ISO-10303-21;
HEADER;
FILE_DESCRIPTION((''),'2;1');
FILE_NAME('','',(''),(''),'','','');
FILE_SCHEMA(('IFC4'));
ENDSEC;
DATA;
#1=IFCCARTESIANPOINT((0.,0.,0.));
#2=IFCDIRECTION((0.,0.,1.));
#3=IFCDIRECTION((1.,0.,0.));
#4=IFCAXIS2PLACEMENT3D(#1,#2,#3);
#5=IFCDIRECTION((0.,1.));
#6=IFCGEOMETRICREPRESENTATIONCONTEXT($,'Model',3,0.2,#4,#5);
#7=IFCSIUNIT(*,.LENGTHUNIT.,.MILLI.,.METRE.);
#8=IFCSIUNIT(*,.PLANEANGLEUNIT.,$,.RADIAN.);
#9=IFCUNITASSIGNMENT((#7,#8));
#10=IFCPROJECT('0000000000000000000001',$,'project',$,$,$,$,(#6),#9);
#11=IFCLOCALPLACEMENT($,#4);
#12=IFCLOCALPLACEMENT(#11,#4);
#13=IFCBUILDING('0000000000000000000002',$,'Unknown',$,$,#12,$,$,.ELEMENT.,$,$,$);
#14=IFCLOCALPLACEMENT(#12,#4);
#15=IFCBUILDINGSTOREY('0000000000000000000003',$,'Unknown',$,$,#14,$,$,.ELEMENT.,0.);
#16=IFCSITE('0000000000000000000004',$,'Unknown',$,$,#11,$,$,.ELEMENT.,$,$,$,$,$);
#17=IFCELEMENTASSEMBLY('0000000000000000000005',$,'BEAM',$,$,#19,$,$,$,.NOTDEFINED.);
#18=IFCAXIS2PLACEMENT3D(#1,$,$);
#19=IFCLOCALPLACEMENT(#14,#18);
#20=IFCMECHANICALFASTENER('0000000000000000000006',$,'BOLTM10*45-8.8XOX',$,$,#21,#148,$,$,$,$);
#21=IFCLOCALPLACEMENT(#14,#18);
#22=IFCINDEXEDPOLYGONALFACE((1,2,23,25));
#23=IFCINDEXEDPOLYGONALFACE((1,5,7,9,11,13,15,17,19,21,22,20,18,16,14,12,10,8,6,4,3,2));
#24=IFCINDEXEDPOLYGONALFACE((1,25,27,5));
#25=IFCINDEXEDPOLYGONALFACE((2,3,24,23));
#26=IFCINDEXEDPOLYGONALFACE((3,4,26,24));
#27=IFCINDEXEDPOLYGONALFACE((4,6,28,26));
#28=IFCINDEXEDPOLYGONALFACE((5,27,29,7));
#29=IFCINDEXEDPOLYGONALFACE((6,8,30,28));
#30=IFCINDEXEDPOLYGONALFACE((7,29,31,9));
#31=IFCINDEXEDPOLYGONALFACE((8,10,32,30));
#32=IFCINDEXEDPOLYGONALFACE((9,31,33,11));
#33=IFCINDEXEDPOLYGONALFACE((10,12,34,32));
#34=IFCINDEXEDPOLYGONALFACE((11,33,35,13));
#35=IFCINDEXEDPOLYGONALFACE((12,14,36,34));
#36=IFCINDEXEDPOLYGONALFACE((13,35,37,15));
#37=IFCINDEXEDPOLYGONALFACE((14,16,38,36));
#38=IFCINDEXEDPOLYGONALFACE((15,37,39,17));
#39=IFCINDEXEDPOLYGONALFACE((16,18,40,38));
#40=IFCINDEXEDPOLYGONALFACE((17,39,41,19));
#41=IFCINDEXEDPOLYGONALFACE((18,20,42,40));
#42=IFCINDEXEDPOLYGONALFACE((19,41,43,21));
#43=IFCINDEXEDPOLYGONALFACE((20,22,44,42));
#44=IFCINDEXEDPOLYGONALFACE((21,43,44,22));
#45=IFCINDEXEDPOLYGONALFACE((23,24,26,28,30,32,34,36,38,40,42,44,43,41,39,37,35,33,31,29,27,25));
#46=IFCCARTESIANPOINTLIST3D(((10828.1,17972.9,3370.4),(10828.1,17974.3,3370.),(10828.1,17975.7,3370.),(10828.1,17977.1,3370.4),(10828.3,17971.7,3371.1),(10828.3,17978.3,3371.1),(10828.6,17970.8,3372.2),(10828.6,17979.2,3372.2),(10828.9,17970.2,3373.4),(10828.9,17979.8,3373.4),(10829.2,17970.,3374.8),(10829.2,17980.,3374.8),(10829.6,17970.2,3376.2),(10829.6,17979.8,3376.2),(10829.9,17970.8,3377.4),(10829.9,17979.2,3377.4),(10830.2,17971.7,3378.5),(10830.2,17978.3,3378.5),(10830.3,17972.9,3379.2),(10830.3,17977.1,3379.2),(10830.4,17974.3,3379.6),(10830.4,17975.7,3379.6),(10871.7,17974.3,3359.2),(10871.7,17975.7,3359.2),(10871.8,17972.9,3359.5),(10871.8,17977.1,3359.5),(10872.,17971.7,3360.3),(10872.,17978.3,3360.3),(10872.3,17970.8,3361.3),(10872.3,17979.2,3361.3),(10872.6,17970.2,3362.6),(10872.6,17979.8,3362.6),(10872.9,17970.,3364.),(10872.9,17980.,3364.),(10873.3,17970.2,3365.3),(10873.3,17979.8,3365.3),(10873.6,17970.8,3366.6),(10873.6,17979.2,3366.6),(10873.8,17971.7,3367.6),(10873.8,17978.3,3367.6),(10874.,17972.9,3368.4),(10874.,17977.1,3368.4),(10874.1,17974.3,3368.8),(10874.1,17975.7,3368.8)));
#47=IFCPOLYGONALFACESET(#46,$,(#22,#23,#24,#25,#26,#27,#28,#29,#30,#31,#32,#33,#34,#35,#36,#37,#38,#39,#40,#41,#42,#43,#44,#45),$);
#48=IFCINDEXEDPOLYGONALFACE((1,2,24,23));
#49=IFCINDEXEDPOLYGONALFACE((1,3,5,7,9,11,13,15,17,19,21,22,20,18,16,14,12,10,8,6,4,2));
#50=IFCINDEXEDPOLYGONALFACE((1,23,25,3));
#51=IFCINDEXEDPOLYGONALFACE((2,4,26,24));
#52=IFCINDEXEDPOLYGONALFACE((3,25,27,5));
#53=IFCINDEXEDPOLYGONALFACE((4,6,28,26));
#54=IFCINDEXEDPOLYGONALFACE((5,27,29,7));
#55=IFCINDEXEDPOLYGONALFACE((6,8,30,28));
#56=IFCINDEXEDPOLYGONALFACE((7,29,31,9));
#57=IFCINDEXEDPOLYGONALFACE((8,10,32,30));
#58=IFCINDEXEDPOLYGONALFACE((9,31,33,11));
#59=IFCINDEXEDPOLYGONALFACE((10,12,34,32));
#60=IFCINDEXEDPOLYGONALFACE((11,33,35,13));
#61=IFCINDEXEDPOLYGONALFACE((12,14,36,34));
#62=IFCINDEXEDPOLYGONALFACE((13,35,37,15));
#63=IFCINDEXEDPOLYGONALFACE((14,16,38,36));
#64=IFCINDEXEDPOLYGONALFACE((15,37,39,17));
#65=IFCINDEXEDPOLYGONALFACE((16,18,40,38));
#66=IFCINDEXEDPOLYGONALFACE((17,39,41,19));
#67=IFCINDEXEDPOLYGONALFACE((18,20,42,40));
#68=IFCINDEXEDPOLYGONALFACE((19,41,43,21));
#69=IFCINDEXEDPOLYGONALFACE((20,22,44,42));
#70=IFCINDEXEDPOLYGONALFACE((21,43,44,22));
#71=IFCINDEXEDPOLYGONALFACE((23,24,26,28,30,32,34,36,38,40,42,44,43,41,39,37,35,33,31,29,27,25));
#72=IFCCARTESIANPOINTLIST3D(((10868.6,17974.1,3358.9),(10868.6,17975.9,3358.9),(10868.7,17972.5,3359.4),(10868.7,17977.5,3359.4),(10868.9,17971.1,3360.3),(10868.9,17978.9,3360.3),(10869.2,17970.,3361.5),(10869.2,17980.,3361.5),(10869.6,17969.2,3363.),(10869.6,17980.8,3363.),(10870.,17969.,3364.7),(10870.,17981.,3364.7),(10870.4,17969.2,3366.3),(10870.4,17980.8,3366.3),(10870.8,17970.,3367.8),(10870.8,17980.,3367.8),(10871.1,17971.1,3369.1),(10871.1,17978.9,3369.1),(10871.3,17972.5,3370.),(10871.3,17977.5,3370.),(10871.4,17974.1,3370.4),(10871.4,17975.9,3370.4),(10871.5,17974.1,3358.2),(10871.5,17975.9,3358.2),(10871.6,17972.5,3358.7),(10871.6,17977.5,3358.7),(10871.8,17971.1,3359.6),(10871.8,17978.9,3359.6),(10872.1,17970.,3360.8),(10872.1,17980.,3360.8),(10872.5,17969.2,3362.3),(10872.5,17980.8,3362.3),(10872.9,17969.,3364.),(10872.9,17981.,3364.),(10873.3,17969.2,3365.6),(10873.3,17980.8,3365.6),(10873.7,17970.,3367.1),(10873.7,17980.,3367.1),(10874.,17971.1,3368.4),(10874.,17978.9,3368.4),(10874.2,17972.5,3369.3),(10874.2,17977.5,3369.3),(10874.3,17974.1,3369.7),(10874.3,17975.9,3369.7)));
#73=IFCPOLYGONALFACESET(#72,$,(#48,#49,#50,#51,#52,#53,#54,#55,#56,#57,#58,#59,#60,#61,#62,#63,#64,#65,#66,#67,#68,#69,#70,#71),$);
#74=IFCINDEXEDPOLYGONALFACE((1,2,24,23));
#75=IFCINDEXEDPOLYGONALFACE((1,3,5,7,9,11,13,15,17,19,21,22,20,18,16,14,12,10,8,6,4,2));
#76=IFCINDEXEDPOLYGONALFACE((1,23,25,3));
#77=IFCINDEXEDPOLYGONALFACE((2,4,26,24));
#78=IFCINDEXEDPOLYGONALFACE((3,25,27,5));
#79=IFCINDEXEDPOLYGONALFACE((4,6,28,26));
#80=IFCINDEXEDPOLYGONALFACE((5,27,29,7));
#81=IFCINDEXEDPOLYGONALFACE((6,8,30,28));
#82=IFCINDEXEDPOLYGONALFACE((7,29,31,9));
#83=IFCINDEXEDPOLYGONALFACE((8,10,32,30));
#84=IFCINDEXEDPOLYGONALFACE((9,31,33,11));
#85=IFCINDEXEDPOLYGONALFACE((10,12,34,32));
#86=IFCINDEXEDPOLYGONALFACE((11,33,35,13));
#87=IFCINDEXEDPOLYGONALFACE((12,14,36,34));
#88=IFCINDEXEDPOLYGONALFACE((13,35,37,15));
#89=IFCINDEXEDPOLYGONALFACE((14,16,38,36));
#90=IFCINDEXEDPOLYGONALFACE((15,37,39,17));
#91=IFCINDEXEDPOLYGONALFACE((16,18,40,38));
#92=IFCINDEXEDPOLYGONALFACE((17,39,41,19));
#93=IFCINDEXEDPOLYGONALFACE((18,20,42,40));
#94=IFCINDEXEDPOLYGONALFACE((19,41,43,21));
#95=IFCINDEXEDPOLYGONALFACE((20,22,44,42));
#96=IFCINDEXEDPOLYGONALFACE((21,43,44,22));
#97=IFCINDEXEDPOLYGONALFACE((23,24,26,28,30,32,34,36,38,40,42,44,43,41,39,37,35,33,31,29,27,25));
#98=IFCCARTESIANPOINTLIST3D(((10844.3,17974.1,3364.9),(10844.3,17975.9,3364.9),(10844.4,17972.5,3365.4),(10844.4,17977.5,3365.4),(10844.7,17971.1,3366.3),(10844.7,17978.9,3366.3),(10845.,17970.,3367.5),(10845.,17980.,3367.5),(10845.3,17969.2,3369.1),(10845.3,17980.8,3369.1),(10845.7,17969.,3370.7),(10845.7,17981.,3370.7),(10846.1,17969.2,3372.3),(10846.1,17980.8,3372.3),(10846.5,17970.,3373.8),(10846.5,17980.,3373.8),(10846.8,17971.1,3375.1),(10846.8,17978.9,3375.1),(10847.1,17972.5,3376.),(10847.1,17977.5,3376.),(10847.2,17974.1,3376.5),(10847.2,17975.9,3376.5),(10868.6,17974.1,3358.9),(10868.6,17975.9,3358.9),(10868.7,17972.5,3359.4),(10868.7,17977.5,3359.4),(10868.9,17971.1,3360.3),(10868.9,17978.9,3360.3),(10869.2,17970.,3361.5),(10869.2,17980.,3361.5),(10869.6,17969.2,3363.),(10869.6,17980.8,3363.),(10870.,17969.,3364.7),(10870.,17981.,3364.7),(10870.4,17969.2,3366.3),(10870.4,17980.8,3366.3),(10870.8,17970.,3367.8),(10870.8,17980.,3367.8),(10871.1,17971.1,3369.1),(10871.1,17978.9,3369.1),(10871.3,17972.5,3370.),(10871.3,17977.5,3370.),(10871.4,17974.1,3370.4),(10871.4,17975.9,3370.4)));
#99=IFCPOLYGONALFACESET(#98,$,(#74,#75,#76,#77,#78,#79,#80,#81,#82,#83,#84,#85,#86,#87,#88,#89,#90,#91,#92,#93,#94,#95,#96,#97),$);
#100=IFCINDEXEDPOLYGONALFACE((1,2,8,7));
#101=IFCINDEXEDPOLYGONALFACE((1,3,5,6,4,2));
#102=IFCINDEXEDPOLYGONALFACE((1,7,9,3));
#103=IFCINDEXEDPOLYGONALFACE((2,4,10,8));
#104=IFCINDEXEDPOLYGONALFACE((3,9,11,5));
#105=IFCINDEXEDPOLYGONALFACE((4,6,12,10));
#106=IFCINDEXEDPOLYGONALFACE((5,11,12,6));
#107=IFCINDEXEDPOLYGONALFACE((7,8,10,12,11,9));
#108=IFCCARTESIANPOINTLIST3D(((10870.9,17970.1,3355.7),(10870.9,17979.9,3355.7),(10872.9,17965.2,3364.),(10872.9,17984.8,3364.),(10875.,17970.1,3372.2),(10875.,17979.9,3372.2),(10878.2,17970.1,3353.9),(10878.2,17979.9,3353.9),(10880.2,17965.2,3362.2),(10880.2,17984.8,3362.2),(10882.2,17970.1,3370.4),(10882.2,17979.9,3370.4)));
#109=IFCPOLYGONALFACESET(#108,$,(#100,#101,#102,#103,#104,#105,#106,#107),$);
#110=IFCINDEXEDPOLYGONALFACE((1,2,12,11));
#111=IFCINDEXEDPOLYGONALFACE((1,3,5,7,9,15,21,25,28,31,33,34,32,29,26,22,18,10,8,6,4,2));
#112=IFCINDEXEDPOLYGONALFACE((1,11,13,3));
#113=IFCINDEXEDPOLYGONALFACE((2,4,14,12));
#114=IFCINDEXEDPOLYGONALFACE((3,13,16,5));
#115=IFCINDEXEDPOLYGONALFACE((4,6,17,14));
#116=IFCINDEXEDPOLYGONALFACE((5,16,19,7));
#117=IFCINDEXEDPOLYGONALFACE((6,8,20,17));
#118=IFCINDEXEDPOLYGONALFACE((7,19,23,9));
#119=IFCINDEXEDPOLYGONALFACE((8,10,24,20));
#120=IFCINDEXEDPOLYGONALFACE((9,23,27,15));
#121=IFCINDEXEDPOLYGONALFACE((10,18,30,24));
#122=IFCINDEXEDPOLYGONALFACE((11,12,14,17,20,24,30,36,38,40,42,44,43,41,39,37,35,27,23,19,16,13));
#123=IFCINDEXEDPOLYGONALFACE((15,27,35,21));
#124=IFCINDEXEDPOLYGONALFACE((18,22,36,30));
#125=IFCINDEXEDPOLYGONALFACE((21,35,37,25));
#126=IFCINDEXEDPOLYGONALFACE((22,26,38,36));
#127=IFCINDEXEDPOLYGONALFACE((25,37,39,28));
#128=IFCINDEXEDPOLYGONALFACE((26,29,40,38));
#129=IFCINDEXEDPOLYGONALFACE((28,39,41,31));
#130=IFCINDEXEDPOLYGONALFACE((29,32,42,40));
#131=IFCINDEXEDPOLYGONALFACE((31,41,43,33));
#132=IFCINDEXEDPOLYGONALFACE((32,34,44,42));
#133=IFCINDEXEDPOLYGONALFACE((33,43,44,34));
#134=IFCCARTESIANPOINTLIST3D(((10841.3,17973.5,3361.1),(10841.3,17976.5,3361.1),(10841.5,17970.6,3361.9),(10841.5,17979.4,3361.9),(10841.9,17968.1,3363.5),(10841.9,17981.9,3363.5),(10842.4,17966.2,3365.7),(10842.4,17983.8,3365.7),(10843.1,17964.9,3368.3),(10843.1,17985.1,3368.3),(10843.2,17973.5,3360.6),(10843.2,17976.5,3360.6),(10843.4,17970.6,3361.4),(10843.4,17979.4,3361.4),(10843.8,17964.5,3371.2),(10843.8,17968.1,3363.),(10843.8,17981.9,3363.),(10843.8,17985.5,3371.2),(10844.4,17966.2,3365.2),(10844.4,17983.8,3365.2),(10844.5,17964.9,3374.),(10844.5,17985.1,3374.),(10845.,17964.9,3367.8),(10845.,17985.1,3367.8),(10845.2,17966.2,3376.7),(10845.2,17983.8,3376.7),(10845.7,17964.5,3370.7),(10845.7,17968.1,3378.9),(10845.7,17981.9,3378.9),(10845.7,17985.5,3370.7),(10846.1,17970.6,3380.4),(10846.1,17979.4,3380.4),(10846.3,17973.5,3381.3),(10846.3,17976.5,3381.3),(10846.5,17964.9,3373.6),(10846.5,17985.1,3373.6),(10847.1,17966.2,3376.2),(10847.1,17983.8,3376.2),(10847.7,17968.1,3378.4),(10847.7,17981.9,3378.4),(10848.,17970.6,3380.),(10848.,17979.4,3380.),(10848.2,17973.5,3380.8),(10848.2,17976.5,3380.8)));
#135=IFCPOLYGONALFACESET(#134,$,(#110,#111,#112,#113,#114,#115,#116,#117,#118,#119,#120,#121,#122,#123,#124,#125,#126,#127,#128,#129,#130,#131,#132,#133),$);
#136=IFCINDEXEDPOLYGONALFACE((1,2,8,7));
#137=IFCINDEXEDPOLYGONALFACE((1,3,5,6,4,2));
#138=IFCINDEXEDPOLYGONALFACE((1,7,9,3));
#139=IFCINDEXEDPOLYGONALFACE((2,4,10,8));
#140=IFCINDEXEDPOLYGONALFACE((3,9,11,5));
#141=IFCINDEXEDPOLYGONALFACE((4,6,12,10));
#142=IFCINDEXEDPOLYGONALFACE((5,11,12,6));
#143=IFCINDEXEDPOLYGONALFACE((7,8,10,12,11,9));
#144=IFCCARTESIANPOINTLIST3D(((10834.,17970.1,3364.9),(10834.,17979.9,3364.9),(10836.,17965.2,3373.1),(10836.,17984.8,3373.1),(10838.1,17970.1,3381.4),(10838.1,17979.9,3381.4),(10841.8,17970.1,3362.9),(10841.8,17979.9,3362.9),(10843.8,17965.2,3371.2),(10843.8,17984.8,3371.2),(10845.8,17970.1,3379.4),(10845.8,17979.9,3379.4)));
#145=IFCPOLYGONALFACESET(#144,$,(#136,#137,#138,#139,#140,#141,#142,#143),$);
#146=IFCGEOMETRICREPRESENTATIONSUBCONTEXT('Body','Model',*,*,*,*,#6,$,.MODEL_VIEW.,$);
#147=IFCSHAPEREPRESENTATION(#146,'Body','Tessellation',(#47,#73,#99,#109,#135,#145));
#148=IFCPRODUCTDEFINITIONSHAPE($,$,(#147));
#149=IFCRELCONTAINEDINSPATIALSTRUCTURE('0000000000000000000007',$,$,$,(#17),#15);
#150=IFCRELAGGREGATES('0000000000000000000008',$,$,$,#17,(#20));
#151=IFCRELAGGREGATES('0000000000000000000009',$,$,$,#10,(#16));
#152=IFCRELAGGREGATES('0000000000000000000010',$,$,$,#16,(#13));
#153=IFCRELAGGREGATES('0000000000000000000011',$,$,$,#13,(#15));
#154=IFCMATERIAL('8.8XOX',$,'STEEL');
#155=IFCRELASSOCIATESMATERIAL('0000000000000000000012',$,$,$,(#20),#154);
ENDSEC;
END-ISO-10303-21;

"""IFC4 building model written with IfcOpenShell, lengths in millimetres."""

from ifc_helpers import new_model, si_unit, direction, frame, origin_with_axes, place, context, subcontext, project, spatial, line, arc, indexed_curve, outline, extrude, source, transform, mapped, material, element, aggregate, save


model = new_model("IFC4")

# Units and contexts
model_context = context("Model", 3, precision=0.2, world=origin_with_axes(), true_north=direction((0.0, 1.0)))
body_context = subcontext(model_context, "Body", "Model", "MODEL_VIEW")
ifc_project = project(units=[si_unit("LENGTHUNIT", "METRE", prefix="MILLI"), si_unit("PLANEANGLEUNIT", "RADIAN")], contexts=[model_context])

# Site, building, storey
site_placement = place(None, origin_with_axes())
site = spatial("IfcSite", under=ifc_project, at=site_placement, Name="Unknown", CompositionType="ELEMENT")
building_placement = place(site_placement, origin_with_axes())
building = spatial("IfcBuilding", under=site, at=building_placement, Name="Unknown", CompositionType="ELEMENT")
storey_placement = place(building_placement, origin_with_axes())
storey = spatial("IfcBuildingStorey", under=building, at=storey_placement, Name="Unknown", CompositionType="ELEMENT", Elevation=0.0)

# Shared definitions
ifc_material_1 = material(Name="8.8XOX", Category="STEEL")

# Element assembly, mechanical fastener
shared_shape_1 = source(origin_with_axes(), body_context, "Body", "SweptSolid", [
    extrude(outline(indexed_curve([(5.0, 0.0), (0.0, 5.0), (-5.0, 0.0), (0.0, -5.0)], segments=[arc(1, 2, 3), arc(3, 4, 1)])), frame((0.0, 0.0, 3.8), z_axis=(0.0, 0.0, -1.0), x_axis=(0.0, 1.0, 0.0)), (0.0, 0.0, 1.0), 45.0),
    extrude(outline(indexed_curve([(6.0, 0.0), (0.0, 6.0), (-6.0, 0.0), (0.0, -6.0)], segments=[arc(1, 2, 3), arc(3, 4, 1)])), frame((0.0, 0.0, 3.8), z_axis=(0.0, 0.0, -1.0), x_axis=(0.0, 1.0, 0.0)), (0.0, 0.0, 1.0), 3.0),
    extrude(outline(indexed_curve([(6.0, 0.0), (0.0, 6.0), (-6.0, 0.0), (0.0, -6.0)], segments=[arc(1, 2, 3), arc(3, 4, 1)])), frame((0.0, 0.0, 0.8), z_axis=(0.0, 0.0, -1.0), x_axis=(0.0, 1.0, 0.0)), (0.0, 0.0, 1.0), 25.0),
    extrude(outline(indexed_curve([(9.8, 0.0), (4.9, 8.5), (-4.9, 8.5), (-9.8, 0.0), (-4.9, -8.5), (4.9, -8.5)], segments=[line(1, 2, 3, 4, 5, 6, 1)])), frame((0.0, 0.0, 11.2), z_axis=(0.0, 0.0, -1.0), x_axis=(0.0, 1.0, 0.0)), (0.0, 0.0, 1.0), 7.5),
    extrude(outline(indexed_curve([(10.5, 0.0), (0.0, 10.5), (-10.5, 0.0), (0.0, -10.5)], segments=[arc(1, 2, 3), arc(3, 4, 1)])), frame((0.0, 0.0, -24.2), z_axis=(0.0, 0.0, -1.0), x_axis=(0.0, 1.0, 0.0)), (0.0, 0.0, 1.0), 2.0),
    extrude(outline(indexed_curve([(9.8, 0.0), (4.9, 8.5), (-4.9, 8.5), (-9.8, 0.0), (-4.9, -8.5), (4.9, -8.5)], segments=[line(1, 2, 3, 4, 5, 6, 1)])), frame((0.0, 0.0, -26.2), z_axis=(0.0, 0.0, -1.0), x_axis=(0.0, 1.0, 0.0)), (0.0, 0.0, 1.0), 8.0),
])
assembly_1_placement = place(storey_placement, frame((10859.1, 12000.0, 3372.5), z_axis=(0.970613, 0.0, -0.240648), x_axis=(0.0, 1.0, 0.0)))
assembly_1 = element("IfcElementAssembly", 1, at=assembly_1_placement, inside=storey, Name="BEAM", PredefinedType="NOTDEFINED")
mechanical_fastener_1_placement = place(assembly_1_placement, frame((5975.0, -5.0, 11.8), z_axis=(0.0, 0.0, 1.0), x_axis=(0.0, 1.0, 0.0)))
mechanical_fastener_1 = element("IfcMechanicalFastener", 2, at=mechanical_fastener_1_placement, material=ifc_material_1, Name="BOLTM10*45-8.8XOX", context=body_context, shape_type="MappedRepresentation", body=[
    mapped(shared_shape_1, transform((0.0, 0.0, 0.0))),
])
aggregate(assembly_1, [mechanical_fastener_1])

save(model, "model.ifc")
